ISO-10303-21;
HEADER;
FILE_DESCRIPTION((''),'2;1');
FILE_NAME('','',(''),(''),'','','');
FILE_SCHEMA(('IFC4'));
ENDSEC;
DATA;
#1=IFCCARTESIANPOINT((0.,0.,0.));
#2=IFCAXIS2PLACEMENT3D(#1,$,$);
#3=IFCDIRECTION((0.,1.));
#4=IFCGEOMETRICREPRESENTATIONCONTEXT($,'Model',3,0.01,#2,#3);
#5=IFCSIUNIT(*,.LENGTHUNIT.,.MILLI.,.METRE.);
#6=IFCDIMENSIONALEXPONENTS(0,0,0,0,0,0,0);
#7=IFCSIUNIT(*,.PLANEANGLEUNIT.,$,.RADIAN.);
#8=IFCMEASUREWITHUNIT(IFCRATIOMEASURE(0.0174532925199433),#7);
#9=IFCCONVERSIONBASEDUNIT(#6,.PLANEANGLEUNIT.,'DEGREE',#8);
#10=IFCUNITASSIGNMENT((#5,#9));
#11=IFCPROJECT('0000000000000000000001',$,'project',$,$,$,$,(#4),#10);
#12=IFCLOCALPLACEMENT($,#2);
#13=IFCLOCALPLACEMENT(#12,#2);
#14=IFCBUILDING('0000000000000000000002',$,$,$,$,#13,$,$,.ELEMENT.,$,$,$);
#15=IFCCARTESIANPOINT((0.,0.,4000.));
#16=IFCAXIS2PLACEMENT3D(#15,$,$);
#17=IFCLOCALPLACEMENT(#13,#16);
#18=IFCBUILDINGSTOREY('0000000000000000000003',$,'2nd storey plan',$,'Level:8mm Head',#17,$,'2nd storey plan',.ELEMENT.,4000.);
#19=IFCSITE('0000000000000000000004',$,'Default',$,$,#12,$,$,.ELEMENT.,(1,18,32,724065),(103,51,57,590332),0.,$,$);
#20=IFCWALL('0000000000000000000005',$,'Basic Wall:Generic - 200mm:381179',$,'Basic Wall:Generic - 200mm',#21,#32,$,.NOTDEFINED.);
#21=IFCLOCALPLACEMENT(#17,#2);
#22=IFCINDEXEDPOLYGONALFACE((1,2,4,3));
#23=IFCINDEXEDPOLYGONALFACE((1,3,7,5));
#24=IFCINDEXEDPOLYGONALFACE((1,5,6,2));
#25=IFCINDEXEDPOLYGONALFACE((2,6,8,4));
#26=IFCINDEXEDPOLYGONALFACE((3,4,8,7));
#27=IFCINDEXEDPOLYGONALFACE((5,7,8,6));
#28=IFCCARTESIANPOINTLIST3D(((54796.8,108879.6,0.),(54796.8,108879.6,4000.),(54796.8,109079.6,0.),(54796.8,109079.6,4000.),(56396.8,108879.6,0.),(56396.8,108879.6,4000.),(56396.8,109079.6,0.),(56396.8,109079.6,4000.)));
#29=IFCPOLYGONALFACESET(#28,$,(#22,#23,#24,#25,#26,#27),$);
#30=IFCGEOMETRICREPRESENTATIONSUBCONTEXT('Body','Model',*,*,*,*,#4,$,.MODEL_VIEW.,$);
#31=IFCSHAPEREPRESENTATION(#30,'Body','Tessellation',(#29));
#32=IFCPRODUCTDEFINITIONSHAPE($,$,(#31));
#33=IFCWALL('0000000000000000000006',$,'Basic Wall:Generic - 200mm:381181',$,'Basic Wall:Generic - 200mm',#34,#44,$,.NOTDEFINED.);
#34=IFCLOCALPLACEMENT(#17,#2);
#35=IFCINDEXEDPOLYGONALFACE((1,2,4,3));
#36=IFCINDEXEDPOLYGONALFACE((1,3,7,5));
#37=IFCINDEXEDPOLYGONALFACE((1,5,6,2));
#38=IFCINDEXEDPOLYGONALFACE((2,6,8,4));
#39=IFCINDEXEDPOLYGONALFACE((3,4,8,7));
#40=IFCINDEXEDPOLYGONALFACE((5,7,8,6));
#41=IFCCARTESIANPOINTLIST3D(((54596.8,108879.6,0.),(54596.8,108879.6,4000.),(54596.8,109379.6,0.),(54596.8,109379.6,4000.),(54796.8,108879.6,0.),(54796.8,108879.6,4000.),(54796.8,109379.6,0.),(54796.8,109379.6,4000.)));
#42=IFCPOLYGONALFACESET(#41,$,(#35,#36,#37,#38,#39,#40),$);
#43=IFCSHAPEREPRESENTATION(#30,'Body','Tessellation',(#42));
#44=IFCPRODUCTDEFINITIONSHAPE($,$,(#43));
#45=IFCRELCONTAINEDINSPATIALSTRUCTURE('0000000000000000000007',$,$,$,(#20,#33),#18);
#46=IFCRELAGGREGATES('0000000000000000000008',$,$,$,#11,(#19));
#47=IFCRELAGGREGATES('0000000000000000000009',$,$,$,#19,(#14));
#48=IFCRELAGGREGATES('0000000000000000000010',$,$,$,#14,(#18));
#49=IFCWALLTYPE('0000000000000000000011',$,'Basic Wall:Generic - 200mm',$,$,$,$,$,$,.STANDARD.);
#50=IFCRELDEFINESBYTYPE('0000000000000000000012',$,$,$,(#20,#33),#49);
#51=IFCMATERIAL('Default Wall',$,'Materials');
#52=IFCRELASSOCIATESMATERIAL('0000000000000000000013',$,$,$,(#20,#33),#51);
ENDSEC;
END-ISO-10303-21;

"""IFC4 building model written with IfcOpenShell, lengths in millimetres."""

from ifc_helpers import new_model, entity, si_unit, converted_unit, direction, frame, origin, place, context, subcontext, project, spatial, indexed_curve, outline, extrude, material, type_object, element, save


model = new_model("IFC4")

# Units and contexts
model_context = context("Model", 3, precision=0.01, world=origin(), true_north=direction((0.0, 1.0)))
body_context = subcontext(model_context, "Body", "Model", "MODEL_VIEW")
ifc_project = project(units=[si_unit("LENGTHUNIT", "METRE", prefix="MILLI"), converted_unit("PLANEANGLEUNIT", "DEGREE", entity("IfcRatioMeasure", 0.0174532925199433), si_unit("PLANEANGLEUNIT", "RADIAN"), dimensions=[0, 0, 0, 0, 0, 0, 0])], contexts=[model_context])

# Site, building, storey
site_placement = place(None, origin())
site = spatial("IfcSite", under=ifc_project, at=site_placement, Name="Default", CompositionType="ELEMENT", RefLatitude=(1, 18, 32, 724065), RefLongitude=(103, 51, 57, 590332), RefElevation=0.0)
building_placement = place(site_placement, origin())
building = spatial("IfcBuilding", under=site, at=building_placement, CompositionType="ELEMENT")
storey_placement = place(building_placement, frame((0.0, 0.0, 4000.0)))
storey = spatial("IfcBuildingStorey", under=building, at=storey_placement, Name="2nd storey plan", ObjectType="Level:8mm Head", LongName="2nd storey plan", CompositionType="ELEMENT", Elevation=4000.0)

# Walls
ifc_material_1 = material(Name="Default Wall", Category="Materials")
wall_type = type_object("IfcWallType", Name="Basic Wall:Generic - 200mm", PredefinedType="STANDARD")
wall_1_placement = place(storey_placement, frame((56396.8, 108979.6, 0.0), z_axis=(0.0, 0.0, 1.0), x_axis=(-1.0, 0.0, 0.0)))
element("IfcWall", 1, at=wall_1_placement, inside=storey, type_object=wall_type, material=ifc_material_1, Name="Basic Wall:Generic - 200mm:381179", ObjectType="Basic Wall:Generic - 200mm", PredefinedType="NOTDEFINED", context=body_context, shape_type="SweptSolid", body=[
    extrude(outline(indexed_curve([(1600.0, 100.0), (0.0, 100.0), (0.0, -100.0), (1600.0, -100.0), (1600.0, 100.0)], self_intersect=False)), origin(), (0.0, 0.0, 1.0), 4000.0),
])
wall_2_placement = place(storey_placement, frame((54696.8, 108879.6, 0.0), z_axis=(0.0, 0.0, 1.0), x_axis=(0.0, 1.0, 0.0)))
element("IfcWall", 2, at=wall_2_placement, inside=storey, type_object=wall_type, material=ifc_material_1, Name="Basic Wall:Generic - 200mm:381181", ObjectType="Basic Wall:Generic - 200mm", PredefinedType="NOTDEFINED", context=body_context, shape_type="SweptSolid", body=[
    extrude(outline(indexed_curve([(500.0, 100.0), (0.0, 100.0), (0.0, -100.0), (500.0, -100.0), (500.0, 100.0)], self_intersect=False)), origin(), (0.0, 0.0, 1.0), 4000.0),
])

save(model, "model.ifc")
